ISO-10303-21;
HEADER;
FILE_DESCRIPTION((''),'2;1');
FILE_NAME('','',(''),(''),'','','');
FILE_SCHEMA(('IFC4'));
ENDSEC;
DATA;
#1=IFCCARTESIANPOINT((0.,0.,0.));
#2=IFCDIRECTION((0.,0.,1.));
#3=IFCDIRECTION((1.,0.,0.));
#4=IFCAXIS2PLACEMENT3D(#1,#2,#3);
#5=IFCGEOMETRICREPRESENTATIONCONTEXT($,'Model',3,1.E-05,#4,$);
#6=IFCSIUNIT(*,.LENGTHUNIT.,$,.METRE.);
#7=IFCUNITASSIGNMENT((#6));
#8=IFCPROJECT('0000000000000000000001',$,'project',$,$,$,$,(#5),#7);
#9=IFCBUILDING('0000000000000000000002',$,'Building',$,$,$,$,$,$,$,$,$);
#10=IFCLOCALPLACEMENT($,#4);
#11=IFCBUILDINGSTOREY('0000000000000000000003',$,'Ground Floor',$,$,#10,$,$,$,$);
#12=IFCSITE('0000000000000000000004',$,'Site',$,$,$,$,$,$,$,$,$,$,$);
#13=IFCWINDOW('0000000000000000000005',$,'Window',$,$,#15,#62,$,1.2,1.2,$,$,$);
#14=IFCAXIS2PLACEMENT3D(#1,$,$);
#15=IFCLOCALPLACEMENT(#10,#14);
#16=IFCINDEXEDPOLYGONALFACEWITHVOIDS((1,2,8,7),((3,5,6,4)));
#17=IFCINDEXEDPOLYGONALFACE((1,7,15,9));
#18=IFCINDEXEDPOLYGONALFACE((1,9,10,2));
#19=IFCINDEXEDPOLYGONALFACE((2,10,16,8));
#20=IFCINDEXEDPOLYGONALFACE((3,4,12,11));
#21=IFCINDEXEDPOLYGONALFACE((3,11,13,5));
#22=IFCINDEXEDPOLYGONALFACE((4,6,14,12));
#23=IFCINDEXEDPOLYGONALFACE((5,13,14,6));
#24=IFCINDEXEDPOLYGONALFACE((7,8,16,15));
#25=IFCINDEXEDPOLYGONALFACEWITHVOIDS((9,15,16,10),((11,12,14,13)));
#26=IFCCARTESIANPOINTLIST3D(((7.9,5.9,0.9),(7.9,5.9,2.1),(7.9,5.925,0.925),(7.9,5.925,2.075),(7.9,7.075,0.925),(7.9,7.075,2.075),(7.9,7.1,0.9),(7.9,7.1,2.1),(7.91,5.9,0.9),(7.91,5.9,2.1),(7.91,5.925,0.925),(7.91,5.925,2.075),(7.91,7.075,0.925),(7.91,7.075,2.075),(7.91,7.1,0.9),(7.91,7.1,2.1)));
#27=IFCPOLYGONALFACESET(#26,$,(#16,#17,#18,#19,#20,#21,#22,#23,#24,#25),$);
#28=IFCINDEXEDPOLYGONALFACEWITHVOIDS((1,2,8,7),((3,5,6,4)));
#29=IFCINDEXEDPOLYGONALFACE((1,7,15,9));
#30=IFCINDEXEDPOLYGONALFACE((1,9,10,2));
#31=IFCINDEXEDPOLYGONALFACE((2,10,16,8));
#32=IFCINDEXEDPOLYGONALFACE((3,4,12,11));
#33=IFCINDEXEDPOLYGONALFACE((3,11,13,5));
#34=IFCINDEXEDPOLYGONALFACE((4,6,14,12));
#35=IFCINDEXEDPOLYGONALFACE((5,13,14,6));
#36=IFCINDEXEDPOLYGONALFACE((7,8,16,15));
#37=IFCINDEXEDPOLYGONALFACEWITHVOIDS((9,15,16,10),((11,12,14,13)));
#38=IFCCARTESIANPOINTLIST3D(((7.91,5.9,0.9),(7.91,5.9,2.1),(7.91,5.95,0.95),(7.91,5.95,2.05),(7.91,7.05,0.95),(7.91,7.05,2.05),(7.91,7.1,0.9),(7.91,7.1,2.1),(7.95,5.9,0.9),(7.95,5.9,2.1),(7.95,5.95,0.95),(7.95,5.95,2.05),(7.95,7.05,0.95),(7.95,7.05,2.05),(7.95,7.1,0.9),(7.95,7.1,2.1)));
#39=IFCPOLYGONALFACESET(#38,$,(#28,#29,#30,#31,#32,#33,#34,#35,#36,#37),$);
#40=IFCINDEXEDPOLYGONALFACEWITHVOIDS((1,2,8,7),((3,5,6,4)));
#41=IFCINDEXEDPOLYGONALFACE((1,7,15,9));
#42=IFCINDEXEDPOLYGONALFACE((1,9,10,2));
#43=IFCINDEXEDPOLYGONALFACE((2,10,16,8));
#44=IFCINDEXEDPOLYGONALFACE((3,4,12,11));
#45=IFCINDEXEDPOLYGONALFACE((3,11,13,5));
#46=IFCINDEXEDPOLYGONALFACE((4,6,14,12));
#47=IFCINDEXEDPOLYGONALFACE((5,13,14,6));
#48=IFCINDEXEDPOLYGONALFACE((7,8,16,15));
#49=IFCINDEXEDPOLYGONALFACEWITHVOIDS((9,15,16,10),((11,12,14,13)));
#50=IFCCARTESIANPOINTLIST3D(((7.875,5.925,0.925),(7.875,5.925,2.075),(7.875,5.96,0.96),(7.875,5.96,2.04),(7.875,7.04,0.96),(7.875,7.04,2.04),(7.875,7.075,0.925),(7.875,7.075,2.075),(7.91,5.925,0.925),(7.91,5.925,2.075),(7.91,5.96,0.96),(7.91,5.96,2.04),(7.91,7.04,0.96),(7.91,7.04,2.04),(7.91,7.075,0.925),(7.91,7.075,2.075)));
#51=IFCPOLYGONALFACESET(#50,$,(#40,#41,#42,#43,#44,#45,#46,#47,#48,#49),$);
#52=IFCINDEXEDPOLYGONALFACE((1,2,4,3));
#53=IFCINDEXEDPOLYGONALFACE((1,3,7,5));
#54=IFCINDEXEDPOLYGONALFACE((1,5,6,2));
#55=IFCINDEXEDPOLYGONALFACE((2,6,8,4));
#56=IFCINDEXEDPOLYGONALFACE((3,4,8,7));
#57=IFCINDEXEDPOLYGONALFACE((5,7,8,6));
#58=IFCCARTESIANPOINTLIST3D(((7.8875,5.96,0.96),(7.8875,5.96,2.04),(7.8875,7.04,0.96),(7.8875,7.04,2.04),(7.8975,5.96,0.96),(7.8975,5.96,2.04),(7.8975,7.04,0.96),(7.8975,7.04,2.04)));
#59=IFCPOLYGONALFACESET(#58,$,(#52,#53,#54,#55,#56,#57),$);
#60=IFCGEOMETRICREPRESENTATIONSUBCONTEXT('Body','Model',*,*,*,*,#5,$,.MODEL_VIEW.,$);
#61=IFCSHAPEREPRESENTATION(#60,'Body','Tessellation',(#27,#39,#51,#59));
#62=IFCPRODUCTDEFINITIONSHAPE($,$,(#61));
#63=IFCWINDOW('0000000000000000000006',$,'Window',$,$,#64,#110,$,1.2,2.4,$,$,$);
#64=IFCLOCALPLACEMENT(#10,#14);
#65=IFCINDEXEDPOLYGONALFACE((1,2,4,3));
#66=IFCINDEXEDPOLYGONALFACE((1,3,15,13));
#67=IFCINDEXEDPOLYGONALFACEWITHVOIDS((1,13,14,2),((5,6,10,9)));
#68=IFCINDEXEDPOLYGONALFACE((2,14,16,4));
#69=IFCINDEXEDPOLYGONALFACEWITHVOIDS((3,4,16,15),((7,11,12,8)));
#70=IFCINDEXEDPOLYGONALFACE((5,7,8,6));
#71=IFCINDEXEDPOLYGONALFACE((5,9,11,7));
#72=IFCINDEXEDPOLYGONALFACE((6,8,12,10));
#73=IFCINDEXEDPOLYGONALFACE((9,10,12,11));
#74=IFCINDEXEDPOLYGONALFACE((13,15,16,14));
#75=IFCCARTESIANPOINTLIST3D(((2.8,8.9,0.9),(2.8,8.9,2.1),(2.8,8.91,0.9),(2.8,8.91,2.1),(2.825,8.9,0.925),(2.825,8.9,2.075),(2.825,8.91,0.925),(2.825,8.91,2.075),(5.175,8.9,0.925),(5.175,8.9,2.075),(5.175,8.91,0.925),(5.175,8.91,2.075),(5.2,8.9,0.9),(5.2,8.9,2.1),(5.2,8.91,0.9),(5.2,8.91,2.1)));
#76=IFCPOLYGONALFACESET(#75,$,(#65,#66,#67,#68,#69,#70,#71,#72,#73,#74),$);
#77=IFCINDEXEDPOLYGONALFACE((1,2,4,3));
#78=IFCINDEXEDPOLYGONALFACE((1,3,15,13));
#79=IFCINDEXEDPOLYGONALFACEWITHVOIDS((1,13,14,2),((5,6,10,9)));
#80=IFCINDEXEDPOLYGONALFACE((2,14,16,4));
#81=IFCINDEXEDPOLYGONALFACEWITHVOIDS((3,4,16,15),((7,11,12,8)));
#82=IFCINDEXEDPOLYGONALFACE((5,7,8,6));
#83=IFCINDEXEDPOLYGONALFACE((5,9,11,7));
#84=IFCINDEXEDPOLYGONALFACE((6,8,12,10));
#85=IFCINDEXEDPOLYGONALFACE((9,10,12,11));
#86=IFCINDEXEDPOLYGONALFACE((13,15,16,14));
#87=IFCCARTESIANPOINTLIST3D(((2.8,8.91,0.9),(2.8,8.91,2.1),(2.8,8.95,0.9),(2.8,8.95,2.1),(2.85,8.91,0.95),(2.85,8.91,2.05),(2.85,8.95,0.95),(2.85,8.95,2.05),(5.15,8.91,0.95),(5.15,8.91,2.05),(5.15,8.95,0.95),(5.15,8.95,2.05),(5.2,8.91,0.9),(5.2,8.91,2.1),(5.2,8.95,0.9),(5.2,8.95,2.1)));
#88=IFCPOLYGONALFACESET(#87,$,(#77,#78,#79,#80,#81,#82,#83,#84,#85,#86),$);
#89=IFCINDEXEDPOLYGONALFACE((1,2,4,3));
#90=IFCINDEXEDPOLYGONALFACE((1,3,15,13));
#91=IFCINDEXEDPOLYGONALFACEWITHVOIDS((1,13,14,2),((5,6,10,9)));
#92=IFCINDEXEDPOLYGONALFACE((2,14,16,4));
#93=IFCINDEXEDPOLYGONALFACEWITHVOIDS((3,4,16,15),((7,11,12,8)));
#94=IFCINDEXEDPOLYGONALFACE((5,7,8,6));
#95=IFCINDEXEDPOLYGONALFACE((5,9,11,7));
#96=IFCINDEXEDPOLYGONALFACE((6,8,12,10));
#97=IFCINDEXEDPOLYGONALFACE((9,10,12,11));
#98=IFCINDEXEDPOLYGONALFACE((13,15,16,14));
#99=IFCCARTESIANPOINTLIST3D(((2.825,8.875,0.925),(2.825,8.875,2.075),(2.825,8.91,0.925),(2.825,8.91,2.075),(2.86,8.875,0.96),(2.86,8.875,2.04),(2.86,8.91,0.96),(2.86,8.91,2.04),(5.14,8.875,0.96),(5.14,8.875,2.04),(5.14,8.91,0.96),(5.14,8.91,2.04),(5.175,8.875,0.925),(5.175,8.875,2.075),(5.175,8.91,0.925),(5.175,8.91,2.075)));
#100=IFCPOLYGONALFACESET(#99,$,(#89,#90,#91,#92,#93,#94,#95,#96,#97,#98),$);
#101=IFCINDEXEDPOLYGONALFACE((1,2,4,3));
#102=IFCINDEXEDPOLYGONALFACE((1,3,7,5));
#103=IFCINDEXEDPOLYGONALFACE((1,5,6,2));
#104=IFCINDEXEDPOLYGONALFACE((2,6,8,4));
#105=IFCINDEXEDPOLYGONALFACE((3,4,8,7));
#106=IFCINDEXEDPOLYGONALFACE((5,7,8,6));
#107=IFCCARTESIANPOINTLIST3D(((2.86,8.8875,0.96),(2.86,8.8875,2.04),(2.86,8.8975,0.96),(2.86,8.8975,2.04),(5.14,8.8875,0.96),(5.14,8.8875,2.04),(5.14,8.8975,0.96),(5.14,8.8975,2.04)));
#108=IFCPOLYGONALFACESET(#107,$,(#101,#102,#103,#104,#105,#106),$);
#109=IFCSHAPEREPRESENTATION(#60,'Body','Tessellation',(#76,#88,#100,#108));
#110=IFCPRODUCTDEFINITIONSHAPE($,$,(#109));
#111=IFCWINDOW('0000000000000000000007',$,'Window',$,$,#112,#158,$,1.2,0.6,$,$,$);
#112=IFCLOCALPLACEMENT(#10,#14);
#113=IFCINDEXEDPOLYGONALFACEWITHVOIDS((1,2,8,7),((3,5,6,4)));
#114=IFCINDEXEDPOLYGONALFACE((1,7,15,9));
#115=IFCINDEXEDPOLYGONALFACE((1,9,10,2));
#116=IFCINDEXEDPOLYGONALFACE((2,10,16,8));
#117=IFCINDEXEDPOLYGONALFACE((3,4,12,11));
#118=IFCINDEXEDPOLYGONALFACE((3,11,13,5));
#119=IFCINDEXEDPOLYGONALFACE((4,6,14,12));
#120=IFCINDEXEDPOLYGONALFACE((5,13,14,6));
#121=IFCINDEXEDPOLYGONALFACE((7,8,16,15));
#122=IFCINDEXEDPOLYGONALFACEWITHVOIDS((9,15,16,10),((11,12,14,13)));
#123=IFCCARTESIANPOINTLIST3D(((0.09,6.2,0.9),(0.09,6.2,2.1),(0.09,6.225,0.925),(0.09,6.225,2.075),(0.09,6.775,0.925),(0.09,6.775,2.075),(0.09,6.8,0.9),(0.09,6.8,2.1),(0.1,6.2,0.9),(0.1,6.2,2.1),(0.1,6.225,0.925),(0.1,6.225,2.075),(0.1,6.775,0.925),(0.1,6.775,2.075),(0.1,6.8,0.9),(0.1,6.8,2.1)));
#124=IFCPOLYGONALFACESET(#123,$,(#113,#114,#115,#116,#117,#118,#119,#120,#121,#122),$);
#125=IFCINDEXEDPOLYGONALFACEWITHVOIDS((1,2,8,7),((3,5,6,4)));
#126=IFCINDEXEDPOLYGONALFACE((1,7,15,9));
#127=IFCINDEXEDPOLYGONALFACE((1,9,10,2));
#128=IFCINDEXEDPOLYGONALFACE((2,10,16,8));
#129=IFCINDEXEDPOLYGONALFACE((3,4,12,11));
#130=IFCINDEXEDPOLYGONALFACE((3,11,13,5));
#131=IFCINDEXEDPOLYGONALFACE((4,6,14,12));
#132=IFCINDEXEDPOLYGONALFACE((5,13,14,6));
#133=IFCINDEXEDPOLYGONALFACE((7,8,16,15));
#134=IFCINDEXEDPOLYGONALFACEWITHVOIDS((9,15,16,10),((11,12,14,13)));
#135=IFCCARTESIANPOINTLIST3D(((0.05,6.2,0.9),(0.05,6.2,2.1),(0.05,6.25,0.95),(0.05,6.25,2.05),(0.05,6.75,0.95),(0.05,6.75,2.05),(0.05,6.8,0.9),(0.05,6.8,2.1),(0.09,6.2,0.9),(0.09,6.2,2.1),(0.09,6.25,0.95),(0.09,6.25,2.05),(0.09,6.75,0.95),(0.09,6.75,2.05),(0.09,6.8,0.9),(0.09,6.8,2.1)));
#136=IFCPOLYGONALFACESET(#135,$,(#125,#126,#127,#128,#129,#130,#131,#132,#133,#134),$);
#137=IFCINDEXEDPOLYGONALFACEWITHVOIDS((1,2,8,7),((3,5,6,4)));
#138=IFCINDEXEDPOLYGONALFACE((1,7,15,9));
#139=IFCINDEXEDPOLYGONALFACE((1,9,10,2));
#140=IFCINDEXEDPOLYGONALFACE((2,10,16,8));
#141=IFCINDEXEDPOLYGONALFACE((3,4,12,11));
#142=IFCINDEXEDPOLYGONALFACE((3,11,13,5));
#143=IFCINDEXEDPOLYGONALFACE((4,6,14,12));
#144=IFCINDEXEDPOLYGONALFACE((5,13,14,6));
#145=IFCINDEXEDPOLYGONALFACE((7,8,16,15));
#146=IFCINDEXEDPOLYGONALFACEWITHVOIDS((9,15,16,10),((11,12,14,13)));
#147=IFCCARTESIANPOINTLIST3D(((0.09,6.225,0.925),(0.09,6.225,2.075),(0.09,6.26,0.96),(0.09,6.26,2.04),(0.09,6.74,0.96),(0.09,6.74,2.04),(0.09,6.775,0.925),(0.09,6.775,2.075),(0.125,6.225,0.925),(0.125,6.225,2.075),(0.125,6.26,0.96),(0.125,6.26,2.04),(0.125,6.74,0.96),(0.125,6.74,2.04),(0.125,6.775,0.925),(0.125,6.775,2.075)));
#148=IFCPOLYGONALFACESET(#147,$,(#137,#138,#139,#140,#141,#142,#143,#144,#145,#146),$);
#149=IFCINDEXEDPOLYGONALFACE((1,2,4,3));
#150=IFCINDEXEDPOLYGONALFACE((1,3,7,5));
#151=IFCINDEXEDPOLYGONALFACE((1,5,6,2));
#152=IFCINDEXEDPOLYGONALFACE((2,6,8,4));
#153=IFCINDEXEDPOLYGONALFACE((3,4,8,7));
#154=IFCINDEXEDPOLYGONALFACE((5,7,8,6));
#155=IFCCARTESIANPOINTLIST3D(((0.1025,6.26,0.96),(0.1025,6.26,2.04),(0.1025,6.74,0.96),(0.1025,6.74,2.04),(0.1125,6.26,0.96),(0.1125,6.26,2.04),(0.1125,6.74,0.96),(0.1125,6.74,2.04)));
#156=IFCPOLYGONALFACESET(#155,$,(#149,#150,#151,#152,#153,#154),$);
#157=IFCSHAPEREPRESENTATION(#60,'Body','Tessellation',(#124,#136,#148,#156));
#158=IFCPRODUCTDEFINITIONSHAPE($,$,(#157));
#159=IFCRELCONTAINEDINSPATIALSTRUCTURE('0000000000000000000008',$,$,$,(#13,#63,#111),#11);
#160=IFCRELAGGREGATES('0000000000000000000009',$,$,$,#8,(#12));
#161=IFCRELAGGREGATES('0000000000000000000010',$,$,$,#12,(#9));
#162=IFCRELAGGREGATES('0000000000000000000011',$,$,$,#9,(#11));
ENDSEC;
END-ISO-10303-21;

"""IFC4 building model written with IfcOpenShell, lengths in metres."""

from ifc_helpers import new_model, si_unit, frame, origin_with_axes, place, context, subcontext, project, spatial, line, indexed_curve, outline, extrude, element, save


model = new_model("IFC4")

# Units and contexts
model_context = context("Model", 3, precision=1e-05, world=origin_with_axes())
body_context = subcontext(model_context, "Body", "Model", "MODEL_VIEW")
ifc_project = project(units=[si_unit("LENGTHUNIT", "METRE")], contexts=[model_context])

# Site, building, storey
site = spatial("IfcSite", under=ifc_project, Name="Site")
building = spatial("IfcBuilding", under=site, Name="Building")
storey_placement = place(None, origin_with_axes())
storey = spatial("IfcBuildingStorey", under=building, at=storey_placement, Name="Ground Floor")

# Windows
window_1_placement = place(storey_placement, frame((8.0, 5.9, 0.9), z_axis=(0.0, 0.0, 1.0), x_axis=(0.0, 1.0, 0.0)))
element("IfcWindow", 1, at=window_1_placement, inside=storey, Name="Window", OverallHeight=1.2, OverallWidth=1.2, context=body_context, shape_type="SweptSolid", body=[
    extrude(outline(indexed_curve([(0.0, 0.0), (1.2, 0.0), (1.2, 1.2), (0.0, 1.2)], segments=[line(1, 2, 3, 4, 1)]), holes=[indexed_curve([(0.025, 0.025), (1.175, 0.025), (1.175, 1.175), (0.025, 1.175)], segments=[line(1, 2, 3, 4, 1)])]), frame((0.0, 0.09, 0.0), z_axis=(0.0, -1.0, 0.0), x_axis=(1.0, 0.0, 0.0)), (0.0, 0.0, -1.0), 0.01),
    extrude(outline(indexed_curve([(0.0, 0.0), (1.2, 0.0), (1.2, 1.2), (0.0, 1.2)], segments=[line(1, 2, 3, 4, 1)]), holes=[indexed_curve([(0.05, 0.05), (1.15, 0.05), (1.15, 1.15), (0.05, 1.15)], segments=[line(1, 2, 3, 4, 1)])]), frame((0.0, 0.05, 0.0), z_axis=(0.0, -1.0, 0.0), x_axis=(1.0, 0.0, 0.0)), (0.0, 0.0, -1.0), 0.04),
    extrude(outline(indexed_curve([(0.0, 0.0), (1.15, 0.0), (1.15, 1.15), (0.0, 1.15)], segments=[line(1, 2, 3, 4, 1)]), holes=[indexed_curve([(0.035, 0.035), (1.115, 0.035), (1.115, 1.115), (0.035, 1.115)], segments=[line(1, 2, 3, 4, 1)])]), frame((0.025, 0.09, 0.025), z_axis=(0.0, -1.0, 0.0), x_axis=(1.0, 0.0, 0.0)), (0.0, 0.0, -1.0), 0.035),
    extrude(outline(indexed_curve([(0.035, 0.035), (1.115, 0.035), (1.115, 1.115), (0.035, 1.115)], segments=[line(1, 2, 3, 4, 1)])), frame((0.025, 0.1025, 0.025), z_axis=(0.0, -1.0, 0.0), x_axis=(1.0, 0.0, 0.0)), (0.0, 0.0, -1.0), 0.01),
])
window_2_placement = place(storey_placement, frame((5.2, 9.0, 0.9), z_axis=(0.0, 0.0, 1.0), x_axis=(-1.0, 0.0, 0.0)))
element("IfcWindow", 2, at=window_2_placement, inside=storey, Name="Window", OverallHeight=1.2, OverallWidth=2.4, context=body_context, shape_type="SweptSolid", body=[
    extrude(outline(indexed_curve([(0.0, 0.0), (2.4, 0.0), (2.4, 1.2), (0.0, 1.2)], segments=[line(1, 2, 3, 4, 1)]), holes=[indexed_curve([(0.025, 0.025), (2.375, 0.025), (2.375, 1.175), (0.025, 1.175)], segments=[line(1, 2, 3, 4, 1)])]), frame((0.0, 0.09, 0.0), z_axis=(0.0, -1.0, 0.0), x_axis=(1.0, 0.0, 0.0)), (0.0, 0.0, -1.0), 0.01),
    extrude(outline(indexed_curve([(0.0, 0.0), (2.4, 0.0), (2.4, 1.2), (0.0, 1.2)], segments=[line(1, 2, 3, 4, 1)]), holes=[indexed_curve([(0.05, 0.05), (2.35, 0.05), (2.35, 1.15), (0.05, 1.15)], segments=[line(1, 2, 3, 4, 1)])]), frame((0.0, 0.05, 0.0), z_axis=(0.0, -1.0, 0.0), x_axis=(1.0, 0.0, 0.0)), (0.0, 0.0, -1.0), 0.04),
    extrude(outline(indexed_curve([(0.0, 0.0), (2.35, 0.0), (2.35, 1.15), (0.0, 1.15)], segments=[line(1, 2, 3, 4, 1)]), holes=[indexed_curve([(0.035, 0.035), (2.315, 0.035), (2.315, 1.115), (0.035, 1.115)], segments=[line(1, 2, 3, 4, 1)])]), frame((0.025, 0.09, 0.025), z_axis=(0.0, -1.0, 0.0), x_axis=(1.0, 0.0, 0.0)), (0.0, 0.0, -1.0), 0.035),
    extrude(outline(indexed_curve([(0.035, 0.035), (2.315, 0.035), (2.315, 1.115), (0.035, 1.115)], segments=[line(1, 2, 3, 4, 1)])), frame((0.025, 0.1025, 0.025), z_axis=(0.0, -1.0, 0.0), x_axis=(1.0, 0.0, 0.0)), (0.0, 0.0, -1.0), 0.01),
])
window_3_placement = place(storey_placement, frame((0.0, 6.8, 0.9), z_axis=(0.0, 0.0, 1.0), x_axis=(0.0, -1.0, 0.0)))
element("IfcWindow", 3, at=window_3_placement, inside=storey, Name="Window", OverallHeight=1.2, OverallWidth=0.6, context=body_context, shape_type="SweptSolid", body=[
    extrude(outline(indexed_curve([(0.0, 0.0), (0.6, 0.0), (0.6, 1.2), (0.0, 1.2)], segments=[line(1, 2, 3, 4, 1)]), holes=[indexed_curve([(0.025, 0.025), (0.575, 0.025), (0.575, 1.175), (0.025, 1.175)], segments=[line(1, 2, 3, 4, 1)])]), frame((0.0, 0.09, 0.0), z_axis=(0.0, -1.0, 0.0), x_axis=(1.0, 0.0, 0.0)), (0.0, 0.0, -1.0), 0.01),
    extrude(outline(indexed_curve([(0.0, 0.0), (0.6, 0.0), (0.6, 1.2), (0.0, 1.2)], segments=[line(1, 2, 3, 4, 1)]), holes=[indexed_curve([(0.05, 0.05), (0.55, 0.05), (0.55, 1.15), (0.05, 1.15)], segments=[line(1, 2, 3, 4, 1)])]), frame((0.0, 0.05, 0.0), z_axis=(0.0, -1.0, 0.0), x_axis=(1.0, 0.0, 0.0)), (0.0, 0.0, -1.0), 0.04),
    extrude(outline(indexed_curve([(0.0, 0.0), (0.55, 0.0), (0.55, 1.15), (0.0, 1.15)], segments=[line(1, 2, 3, 4, 1)]), holes=[indexed_curve([(0.035, 0.035), (0.515, 0.035), (0.515, 1.115), (0.035, 1.115)], segments=[line(1, 2, 3, 4, 1)])]), frame((0.025, 0.09, 0.025), z_axis=(0.0, -1.0, 0.0), x_axis=(1.0, 0.0, 0.0)), (0.0, 0.0, -1.0), 0.035),
    extrude(outline(indexed_curve([(0.035, 0.035), (0.515, 0.035), (0.515, 1.115), (0.035, 1.115)], segments=[line(1, 2, 3, 4, 1)])), frame((0.025, 0.1025, 0.025), z_axis=(0.0, -1.0, 0.0), x_axis=(1.0, 0.0, 0.0)), (0.0, 0.0, -1.0), 0.01),
])

save(model, "model.ifc")
